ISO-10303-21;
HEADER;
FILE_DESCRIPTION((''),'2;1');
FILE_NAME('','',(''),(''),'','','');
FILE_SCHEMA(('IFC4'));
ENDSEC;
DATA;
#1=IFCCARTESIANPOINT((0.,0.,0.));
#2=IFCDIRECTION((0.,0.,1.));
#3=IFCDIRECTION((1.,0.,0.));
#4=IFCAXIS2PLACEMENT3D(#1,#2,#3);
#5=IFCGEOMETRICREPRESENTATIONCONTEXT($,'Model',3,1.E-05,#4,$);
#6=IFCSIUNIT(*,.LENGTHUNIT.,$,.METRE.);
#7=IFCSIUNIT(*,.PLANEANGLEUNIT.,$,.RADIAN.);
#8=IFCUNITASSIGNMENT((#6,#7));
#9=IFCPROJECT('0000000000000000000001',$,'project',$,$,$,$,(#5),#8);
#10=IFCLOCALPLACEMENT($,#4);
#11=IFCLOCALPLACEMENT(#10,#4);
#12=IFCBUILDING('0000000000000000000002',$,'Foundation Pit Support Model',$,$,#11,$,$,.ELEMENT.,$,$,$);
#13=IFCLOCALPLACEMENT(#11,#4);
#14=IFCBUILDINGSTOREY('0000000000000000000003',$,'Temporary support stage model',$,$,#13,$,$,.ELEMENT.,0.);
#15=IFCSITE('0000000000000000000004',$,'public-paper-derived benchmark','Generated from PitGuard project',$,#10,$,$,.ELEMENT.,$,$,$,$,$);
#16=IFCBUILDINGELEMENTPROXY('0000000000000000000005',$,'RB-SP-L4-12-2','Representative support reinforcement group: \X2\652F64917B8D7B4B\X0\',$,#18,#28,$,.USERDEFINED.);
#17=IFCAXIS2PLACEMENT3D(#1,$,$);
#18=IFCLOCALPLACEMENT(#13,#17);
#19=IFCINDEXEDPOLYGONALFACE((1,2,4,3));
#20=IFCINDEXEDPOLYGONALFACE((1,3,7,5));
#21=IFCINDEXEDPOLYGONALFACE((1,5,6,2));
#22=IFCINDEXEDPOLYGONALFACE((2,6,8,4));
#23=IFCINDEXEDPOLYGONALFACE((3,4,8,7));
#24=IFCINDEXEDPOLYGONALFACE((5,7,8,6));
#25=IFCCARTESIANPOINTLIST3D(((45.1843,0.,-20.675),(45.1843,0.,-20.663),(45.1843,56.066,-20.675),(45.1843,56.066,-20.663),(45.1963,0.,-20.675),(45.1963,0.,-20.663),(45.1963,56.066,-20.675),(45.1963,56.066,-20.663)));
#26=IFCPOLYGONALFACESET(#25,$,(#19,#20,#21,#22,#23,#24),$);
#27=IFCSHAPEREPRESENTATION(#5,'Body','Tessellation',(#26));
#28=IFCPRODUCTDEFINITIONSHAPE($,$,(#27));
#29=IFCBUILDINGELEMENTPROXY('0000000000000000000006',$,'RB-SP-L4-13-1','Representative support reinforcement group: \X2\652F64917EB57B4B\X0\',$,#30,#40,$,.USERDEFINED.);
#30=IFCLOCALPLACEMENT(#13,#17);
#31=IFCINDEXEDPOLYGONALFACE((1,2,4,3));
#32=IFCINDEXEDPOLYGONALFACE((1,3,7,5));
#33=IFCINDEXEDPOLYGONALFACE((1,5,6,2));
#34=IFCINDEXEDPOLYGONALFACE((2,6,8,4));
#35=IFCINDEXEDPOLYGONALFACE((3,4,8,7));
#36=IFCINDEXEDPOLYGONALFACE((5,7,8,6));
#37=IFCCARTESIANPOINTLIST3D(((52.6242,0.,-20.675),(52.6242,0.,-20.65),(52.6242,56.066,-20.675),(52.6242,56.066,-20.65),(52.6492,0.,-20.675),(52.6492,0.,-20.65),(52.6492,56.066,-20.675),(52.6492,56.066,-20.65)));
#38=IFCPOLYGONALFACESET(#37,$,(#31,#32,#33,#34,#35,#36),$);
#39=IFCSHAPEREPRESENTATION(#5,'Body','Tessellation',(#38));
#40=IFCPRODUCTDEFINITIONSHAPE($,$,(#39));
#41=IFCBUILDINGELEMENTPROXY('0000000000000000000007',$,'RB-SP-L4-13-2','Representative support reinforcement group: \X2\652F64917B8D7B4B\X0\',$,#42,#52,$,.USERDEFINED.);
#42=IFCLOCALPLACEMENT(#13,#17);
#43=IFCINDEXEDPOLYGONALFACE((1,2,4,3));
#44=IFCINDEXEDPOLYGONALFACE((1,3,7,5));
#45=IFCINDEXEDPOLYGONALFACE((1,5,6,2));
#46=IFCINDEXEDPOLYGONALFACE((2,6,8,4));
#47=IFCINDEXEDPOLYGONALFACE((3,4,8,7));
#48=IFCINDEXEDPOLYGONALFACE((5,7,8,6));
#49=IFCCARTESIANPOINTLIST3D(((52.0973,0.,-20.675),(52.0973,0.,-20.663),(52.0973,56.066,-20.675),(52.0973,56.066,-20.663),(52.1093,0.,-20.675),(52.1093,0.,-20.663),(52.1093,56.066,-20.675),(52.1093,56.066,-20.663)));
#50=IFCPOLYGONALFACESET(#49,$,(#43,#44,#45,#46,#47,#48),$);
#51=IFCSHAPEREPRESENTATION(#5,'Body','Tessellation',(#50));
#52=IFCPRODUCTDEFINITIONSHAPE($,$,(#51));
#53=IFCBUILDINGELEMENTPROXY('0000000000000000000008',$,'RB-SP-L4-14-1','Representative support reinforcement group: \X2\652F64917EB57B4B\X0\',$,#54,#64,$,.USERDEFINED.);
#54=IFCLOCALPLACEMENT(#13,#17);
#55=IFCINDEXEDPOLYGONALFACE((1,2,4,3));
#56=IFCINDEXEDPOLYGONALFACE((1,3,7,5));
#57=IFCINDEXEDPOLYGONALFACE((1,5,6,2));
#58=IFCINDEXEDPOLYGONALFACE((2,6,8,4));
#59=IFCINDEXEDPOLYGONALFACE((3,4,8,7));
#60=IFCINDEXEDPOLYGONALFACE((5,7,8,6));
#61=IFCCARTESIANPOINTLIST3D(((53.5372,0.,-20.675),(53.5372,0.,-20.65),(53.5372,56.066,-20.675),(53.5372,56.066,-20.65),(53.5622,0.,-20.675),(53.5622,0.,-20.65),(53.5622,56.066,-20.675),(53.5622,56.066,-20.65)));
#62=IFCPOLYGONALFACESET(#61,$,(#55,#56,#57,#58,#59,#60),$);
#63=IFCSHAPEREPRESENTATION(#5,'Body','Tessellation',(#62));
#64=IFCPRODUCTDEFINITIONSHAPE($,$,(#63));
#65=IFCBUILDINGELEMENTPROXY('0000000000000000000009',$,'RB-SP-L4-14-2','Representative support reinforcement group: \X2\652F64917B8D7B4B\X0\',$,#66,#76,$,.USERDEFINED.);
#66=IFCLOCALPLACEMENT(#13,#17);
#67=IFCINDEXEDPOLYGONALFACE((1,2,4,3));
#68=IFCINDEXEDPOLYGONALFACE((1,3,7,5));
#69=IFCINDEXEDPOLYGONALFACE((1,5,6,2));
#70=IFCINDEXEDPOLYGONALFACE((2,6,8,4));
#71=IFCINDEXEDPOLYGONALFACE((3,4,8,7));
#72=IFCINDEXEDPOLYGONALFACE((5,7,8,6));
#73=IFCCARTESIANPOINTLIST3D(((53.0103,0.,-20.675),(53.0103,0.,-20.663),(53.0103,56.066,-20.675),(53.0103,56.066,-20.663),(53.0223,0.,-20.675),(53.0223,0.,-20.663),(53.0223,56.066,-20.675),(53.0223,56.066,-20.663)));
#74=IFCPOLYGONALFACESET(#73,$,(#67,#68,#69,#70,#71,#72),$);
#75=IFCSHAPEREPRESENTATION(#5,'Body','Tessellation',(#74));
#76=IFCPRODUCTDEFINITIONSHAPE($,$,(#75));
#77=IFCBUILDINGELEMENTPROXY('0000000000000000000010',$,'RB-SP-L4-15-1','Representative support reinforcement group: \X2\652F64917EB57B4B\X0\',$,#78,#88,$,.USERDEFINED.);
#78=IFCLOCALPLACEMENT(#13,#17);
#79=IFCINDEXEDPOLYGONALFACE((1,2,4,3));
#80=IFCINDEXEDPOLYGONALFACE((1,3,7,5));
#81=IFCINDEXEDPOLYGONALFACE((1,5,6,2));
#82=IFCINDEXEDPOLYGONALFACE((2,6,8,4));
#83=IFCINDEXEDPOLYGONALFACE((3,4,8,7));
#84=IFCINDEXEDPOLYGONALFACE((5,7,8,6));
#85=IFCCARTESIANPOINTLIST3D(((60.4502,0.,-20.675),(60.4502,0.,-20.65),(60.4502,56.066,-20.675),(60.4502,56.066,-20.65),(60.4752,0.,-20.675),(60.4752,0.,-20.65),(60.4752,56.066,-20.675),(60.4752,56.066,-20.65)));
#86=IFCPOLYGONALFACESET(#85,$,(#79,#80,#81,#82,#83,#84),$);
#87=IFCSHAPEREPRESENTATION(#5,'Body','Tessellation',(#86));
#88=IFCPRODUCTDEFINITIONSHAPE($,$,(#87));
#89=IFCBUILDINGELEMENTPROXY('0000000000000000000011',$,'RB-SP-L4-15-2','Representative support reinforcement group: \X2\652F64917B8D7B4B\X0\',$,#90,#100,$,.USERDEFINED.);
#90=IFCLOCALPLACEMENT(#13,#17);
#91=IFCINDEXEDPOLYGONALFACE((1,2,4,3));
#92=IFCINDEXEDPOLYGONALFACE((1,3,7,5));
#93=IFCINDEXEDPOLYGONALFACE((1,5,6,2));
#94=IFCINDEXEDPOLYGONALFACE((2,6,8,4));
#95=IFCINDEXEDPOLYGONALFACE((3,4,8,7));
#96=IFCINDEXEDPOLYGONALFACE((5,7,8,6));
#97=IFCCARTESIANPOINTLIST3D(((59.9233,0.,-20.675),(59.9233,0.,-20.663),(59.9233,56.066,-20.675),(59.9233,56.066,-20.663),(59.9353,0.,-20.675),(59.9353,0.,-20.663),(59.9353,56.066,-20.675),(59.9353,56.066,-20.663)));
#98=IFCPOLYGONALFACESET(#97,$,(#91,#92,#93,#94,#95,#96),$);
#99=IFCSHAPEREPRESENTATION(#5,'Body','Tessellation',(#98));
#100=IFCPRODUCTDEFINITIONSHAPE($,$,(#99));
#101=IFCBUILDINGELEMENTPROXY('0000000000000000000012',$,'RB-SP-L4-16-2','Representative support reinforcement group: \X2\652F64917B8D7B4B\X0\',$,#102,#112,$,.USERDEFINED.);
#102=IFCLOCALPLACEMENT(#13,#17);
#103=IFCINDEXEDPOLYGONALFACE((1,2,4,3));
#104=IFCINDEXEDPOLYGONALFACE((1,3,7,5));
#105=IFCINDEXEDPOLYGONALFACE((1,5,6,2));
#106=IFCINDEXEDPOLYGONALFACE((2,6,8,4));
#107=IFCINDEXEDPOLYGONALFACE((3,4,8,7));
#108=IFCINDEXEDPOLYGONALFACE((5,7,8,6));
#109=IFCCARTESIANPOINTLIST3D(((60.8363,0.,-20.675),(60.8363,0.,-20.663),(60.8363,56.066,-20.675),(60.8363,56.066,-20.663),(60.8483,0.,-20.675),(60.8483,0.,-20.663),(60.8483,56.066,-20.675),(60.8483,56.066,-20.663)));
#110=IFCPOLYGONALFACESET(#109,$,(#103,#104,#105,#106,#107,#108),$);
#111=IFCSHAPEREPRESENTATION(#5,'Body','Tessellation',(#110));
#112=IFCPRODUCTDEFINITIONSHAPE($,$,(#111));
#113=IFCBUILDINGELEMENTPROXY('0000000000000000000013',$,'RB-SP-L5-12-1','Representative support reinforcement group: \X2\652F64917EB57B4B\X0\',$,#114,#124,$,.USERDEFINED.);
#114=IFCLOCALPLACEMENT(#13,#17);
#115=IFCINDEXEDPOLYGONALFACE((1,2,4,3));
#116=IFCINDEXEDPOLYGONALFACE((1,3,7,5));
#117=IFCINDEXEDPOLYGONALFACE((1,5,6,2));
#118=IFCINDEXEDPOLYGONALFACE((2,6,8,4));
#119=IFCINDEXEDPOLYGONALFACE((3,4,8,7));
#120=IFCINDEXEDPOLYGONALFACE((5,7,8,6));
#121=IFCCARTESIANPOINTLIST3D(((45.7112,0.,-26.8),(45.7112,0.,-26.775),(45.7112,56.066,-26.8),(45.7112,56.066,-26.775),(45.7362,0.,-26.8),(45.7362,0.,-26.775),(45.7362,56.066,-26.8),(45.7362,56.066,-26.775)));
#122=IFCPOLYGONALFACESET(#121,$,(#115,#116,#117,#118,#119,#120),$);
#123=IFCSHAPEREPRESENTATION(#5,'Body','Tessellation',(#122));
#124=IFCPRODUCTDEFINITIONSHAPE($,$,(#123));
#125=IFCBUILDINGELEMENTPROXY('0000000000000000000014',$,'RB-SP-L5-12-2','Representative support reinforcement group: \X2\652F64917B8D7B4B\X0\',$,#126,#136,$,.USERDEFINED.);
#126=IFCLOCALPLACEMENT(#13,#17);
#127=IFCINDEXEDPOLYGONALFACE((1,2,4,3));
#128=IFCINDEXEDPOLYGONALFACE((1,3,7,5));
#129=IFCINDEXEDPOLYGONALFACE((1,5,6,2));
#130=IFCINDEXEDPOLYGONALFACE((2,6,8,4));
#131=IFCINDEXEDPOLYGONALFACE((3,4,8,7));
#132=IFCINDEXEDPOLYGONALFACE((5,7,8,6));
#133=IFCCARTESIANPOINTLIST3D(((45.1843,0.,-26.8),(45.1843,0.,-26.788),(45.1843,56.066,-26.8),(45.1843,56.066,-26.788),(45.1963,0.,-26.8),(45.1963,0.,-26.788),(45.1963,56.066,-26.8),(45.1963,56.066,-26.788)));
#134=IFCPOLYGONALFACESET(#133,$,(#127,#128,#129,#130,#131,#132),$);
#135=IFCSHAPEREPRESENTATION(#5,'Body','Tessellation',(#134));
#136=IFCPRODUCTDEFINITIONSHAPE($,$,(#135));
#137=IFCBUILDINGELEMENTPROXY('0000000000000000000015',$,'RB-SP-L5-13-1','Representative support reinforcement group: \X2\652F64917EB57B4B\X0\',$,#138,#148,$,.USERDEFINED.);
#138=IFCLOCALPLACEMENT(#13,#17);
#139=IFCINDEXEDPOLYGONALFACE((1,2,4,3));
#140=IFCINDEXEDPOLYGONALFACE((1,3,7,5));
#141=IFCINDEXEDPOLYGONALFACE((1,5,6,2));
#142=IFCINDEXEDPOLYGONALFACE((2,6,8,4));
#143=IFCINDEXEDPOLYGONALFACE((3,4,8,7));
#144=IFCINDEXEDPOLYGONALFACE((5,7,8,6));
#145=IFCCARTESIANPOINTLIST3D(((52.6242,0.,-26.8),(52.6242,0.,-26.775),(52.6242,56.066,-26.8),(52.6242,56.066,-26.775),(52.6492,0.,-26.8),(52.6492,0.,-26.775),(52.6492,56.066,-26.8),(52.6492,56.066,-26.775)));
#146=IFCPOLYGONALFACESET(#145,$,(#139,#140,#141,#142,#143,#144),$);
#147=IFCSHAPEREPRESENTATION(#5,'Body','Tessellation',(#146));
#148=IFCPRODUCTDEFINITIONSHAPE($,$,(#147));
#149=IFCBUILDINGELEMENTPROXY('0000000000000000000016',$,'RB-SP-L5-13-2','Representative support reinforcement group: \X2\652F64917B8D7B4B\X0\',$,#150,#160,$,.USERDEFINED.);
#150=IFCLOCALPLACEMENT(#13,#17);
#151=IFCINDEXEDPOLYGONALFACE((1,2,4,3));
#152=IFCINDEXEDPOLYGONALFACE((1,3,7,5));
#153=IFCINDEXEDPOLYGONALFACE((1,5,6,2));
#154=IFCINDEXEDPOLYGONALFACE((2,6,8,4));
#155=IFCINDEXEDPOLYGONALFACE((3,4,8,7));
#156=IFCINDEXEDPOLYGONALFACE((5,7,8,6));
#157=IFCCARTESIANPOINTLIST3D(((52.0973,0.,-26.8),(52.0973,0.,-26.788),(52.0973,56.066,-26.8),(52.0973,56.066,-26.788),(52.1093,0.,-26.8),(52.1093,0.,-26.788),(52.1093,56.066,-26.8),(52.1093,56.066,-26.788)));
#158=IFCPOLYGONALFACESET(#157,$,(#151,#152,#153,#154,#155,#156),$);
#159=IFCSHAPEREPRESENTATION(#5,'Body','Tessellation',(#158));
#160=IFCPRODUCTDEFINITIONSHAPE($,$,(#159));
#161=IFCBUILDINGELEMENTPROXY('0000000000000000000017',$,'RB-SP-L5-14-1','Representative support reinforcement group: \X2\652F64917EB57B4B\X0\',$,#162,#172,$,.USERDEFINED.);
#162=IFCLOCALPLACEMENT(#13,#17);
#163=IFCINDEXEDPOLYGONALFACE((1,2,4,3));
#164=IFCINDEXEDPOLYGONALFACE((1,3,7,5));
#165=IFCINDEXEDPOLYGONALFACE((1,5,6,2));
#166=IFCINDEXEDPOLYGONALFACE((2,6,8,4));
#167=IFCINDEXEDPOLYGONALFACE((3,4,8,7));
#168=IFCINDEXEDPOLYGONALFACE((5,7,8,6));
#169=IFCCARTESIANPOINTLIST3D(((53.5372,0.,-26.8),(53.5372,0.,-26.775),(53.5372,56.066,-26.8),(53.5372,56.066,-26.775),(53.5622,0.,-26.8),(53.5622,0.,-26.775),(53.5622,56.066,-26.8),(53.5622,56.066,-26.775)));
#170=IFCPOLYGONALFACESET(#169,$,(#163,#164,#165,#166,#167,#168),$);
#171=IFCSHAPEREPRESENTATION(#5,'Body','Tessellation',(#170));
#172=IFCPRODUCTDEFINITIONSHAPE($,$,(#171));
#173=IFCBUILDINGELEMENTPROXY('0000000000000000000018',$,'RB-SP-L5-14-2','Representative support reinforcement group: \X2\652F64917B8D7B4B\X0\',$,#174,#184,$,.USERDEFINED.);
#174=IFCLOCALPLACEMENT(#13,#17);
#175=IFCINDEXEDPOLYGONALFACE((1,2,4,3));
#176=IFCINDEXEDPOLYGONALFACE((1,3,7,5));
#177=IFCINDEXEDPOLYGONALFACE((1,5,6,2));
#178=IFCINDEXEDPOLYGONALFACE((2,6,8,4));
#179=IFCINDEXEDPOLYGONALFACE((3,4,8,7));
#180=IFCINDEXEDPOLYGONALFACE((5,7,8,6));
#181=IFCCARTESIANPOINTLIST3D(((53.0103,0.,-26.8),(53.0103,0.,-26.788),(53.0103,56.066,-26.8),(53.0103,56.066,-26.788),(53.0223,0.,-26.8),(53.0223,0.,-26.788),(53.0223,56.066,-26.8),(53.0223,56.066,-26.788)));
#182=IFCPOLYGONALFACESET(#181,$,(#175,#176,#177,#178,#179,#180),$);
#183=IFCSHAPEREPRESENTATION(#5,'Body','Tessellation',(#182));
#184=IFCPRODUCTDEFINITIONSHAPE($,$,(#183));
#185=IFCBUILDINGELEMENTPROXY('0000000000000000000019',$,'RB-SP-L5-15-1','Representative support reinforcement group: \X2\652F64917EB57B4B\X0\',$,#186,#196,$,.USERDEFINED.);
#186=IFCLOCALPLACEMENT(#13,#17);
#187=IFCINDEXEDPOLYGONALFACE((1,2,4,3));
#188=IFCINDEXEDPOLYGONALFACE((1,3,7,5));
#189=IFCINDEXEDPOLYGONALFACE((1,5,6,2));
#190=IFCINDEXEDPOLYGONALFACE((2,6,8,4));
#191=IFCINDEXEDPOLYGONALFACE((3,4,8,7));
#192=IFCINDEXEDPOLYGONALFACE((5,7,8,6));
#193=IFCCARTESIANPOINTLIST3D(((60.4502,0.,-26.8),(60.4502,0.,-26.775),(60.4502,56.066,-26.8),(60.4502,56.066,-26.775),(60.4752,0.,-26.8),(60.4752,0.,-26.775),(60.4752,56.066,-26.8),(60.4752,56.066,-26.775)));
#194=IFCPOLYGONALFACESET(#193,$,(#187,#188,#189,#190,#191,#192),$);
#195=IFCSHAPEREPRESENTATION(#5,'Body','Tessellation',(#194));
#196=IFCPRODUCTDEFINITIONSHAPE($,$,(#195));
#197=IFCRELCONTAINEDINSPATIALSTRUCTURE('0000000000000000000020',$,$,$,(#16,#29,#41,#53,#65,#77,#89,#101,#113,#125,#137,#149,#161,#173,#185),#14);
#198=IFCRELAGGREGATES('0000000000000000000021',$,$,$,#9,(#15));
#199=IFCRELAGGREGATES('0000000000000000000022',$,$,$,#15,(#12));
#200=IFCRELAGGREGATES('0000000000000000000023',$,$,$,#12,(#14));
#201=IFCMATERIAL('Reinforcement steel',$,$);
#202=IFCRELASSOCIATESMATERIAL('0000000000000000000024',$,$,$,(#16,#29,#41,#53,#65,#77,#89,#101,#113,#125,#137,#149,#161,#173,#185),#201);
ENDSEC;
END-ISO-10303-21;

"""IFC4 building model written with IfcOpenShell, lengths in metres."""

from ifc_helpers import new_model, si_unit, frame, origin_with_axes, origin_2d, place, context, project, spatial, rectangle, extrude, material, element, save


model = new_model("IFC4")

# Units and contexts
model_context = context("Model", 3, precision=1e-05, world=origin_with_axes())
ifc_project = project(units=[si_unit("LENGTHUNIT", "METRE"), si_unit("PLANEANGLEUNIT", "RADIAN")], contexts=[model_context])

# Site, building, storey
site_placement = place(None, origin_with_axes())
site = spatial("IfcSite", under=ifc_project, at=site_placement, Name="public-paper-derived benchmark", Description="Generated from PitGuard project", CompositionType="ELEMENT")
building_placement = place(site_placement, origin_with_axes())
building = spatial("IfcBuilding", under=site, at=building_placement, Name="Foundation Pit Support Model", CompositionType="ELEMENT")
storey_placement = place(building_placement, origin_with_axes())
storey = spatial("IfcBuildingStorey", under=building, at=storey_placement, Name="Temporary support stage model", CompositionType="ELEMENT", Elevation=0.0)

# Building element proxies
ifc_material_1 = material(Name="Reinforcement steel")
proxy_1_placement = place(storey_placement, frame((45.1903, 28.033, -20.675), z_axis=(0.0, 0.0, 1.0), x_axis=(0.0, 1.0, 0.0)))
element("IfcBuildingElementProxy", 1, at=proxy_1_placement, inside=storey, material=ifc_material_1, Name="RB-SP-L4-12-2", Description="Representative support reinforcement group: 支撑箍筋", PredefinedType="USERDEFINED", context=model_context, shape_type="SweptSolid", body=[
    extrude(rectangle(XDim=56.066, YDim=0.012, at=origin_2d()), origin_with_axes(), (0.0, 0.0, 1.0), 0.012),
])
proxy_2_placement = place(storey_placement, frame((52.6367, 28.033, -20.675), z_axis=(0.0, 0.0, 1.0), x_axis=(0.0, 1.0, 0.0)))
element("IfcBuildingElementProxy", 2, at=proxy_2_placement, inside=storey, material=ifc_material_1, Name="RB-SP-L4-13-1", Description="Representative support reinforcement group: 支撑纵筋", PredefinedType="USERDEFINED", context=model_context, shape_type="SweptSolid", body=[
    extrude(rectangle(XDim=56.066, YDim=0.025, at=origin_2d()), origin_with_axes(), (0.0, 0.0, 1.0), 0.025),
])
proxy_3_placement = place(storey_placement, frame((52.1033, 28.033, -20.675), z_axis=(0.0, 0.0, 1.0), x_axis=(0.0, 1.0, 0.0)))
element("IfcBuildingElementProxy", 3, at=proxy_3_placement, inside=storey, material=ifc_material_1, Name="RB-SP-L4-13-2", Description="Representative support reinforcement group: 支撑箍筋", PredefinedType="USERDEFINED", context=model_context, shape_type="SweptSolid", body=[
    extrude(rectangle(XDim=56.066, YDim=0.012, at=origin_2d()), origin_with_axes(), (0.0, 0.0, 1.0), 0.012),
])
proxy_4_placement = place(storey_placement, frame((53.5497, 28.033, -20.675), z_axis=(0.0, 0.0, 1.0), x_axis=(0.0, 1.0, 0.0)))
element("IfcBuildingElementProxy", 4, at=proxy_4_placement, inside=storey, material=ifc_material_1, Name="RB-SP-L4-14-1", Description="Representative support reinforcement group: 支撑纵筋", PredefinedType="USERDEFINED", context=model_context, shape_type="SweptSolid", body=[
    extrude(rectangle(XDim=56.066, YDim=0.025, at=origin_2d()), origin_with_axes(), (0.0, 0.0, 1.0), 0.025),
])
proxy_5_placement = place(storey_placement, frame((53.0163, 28.033, -20.675), z_axis=(0.0, 0.0, 1.0), x_axis=(0.0, 1.0, 0.0)))
element("IfcBuildingElementProxy", 5, at=proxy_5_placement, inside=storey, material=ifc_material_1, Name="RB-SP-L4-14-2", Description="Representative support reinforcement group: 支撑箍筋", PredefinedType="USERDEFINED", context=model_context, shape_type="SweptSolid", body=[
    extrude(rectangle(XDim=56.066, YDim=0.012, at=origin_2d()), origin_with_axes(), (0.0, 0.0, 1.0), 0.012),
])
proxy_6_placement = place(storey_placement, frame((60.4627, 28.033, -20.675), z_axis=(0.0, 0.0, 1.0), x_axis=(0.0, 1.0, 0.0)))
element("IfcBuildingElementProxy", 6, at=proxy_6_placement, inside=storey, material=ifc_material_1, Name="RB-SP-L4-15-1", Description="Representative support reinforcement group: 支撑纵筋", PredefinedType="USERDEFINED", context=model_context, shape_type="SweptSolid", body=[
    extrude(rectangle(XDim=56.066, YDim=0.025, at=origin_2d()), origin_with_axes(), (0.0, 0.0, 1.0), 0.025),
])
for number, where, z_axis, x_axis, name in (
    (7, (59.9293, 28.033, -20.675), (0.0, 0.0, 1.0), (0.0, 1.0, 0.0), "RB-SP-L4-15-2"),
    (8, (60.8423, 28.033, -20.675), (0.0, 0.0, 1.0), (0.0, 1.0, 0.0), "RB-SP-L4-16-2"),
):
    element("IfcBuildingElementProxy", number, at=place(storey_placement, frame(where, z_axis=z_axis, x_axis=x_axis)), inside=storey, material=ifc_material_1, Name=name, Description="Representative support reinforcement group: 支撑箍筋", PredefinedType="USERDEFINED", context=model_context, shape_type="SweptSolid", body=[
        extrude(rectangle(XDim=56.066, YDim=0.012, at=origin_2d()), origin_with_axes(), (0.0, 0.0, 1.0), 0.012),
    ])
proxy_7_placement = place(storey_placement, frame((45.7237, 28.033, -26.8), z_axis=(0.0, 0.0, 1.0), x_axis=(0.0, 1.0, 0.0)))
element("IfcBuildingElementProxy", 9, at=proxy_7_placement, inside=storey, material=ifc_material_1, Name="RB-SP-L5-12-1", Description="Representative support reinforcement group: 支撑纵筋", PredefinedType="USERDEFINED", context=model_context, shape_type="SweptSolid", body=[
    extrude(rectangle(XDim=56.066, YDim=0.025, at=origin_2d()), origin_with_axes(), (0.0, 0.0, 1.0), 0.025),
])
proxy_8_placement = place(storey_placement, frame((45.1903, 28.033, -26.8), z_axis=(0.0, 0.0, 1.0), x_axis=(0.0, 1.0, 0.0)))
element("IfcBuildingElementProxy", 10, at=proxy_8_placement, inside=storey, material=ifc_material_1, Name="RB-SP-L5-12-2", Description="Representative support reinforcement group: 支撑箍筋", PredefinedType="USERDEFINED", context=model_context, shape_type="SweptSolid", body=[
    extrude(rectangle(XDim=56.066, YDim=0.012, at=origin_2d()), origin_with_axes(), (0.0, 0.0, 1.0), 0.012),
])
proxy_9_placement = place(storey_placement, frame((52.6367, 28.033, -26.8), z_axis=(0.0, 0.0, 1.0), x_axis=(0.0, 1.0, 0.0)))
element("IfcBuildingElementProxy", 11, at=proxy_9_placement, inside=storey, material=ifc_material_1, Name="RB-SP-L5-13-1", Description="Representative support reinforcement group: 支撑纵筋", PredefinedType="USERDEFINED", context=model_context, shape_type="SweptSolid", body=[
    extrude(rectangle(XDim=56.066, YDim=0.025, at=origin_2d()), origin_with_axes(), (0.0, 0.0, 1.0), 0.025),
])
proxy_10_placement = place(storey_placement, frame((52.1033, 28.033, -26.8), z_axis=(0.0, 0.0, 1.0), x_axis=(0.0, 1.0, 0.0)))
element("IfcBuildingElementProxy", 12, at=proxy_10_placement, inside=storey, material=ifc_material_1, Name="RB-SP-L5-13-2", Description="Representative support reinforcement group: 支撑箍筋", PredefinedType="USERDEFINED", context=model_context, shape_type="SweptSolid", body=[
    extrude(rectangle(XDim=56.066, YDim=0.012, at=origin_2d()), origin_with_axes(), (0.0, 0.0, 1.0), 0.012),
])
proxy_11_placement = place(storey_placement, frame((53.5497, 28.033, -26.8), z_axis=(0.0, 0.0, 1.0), x_axis=(0.0, 1.0, 0.0)))
element("IfcBuildingElementProxy", 13, at=proxy_11_placement, inside=storey, material=ifc_material_1, Name="RB-SP-L5-14-1", Description="Representative support reinforcement group: 支撑纵筋", PredefinedType="USERDEFINED", context=model_context, shape_type="SweptSolid", body=[
    extrude(rectangle(XDim=56.066, YDim=0.025, at=origin_2d()), origin_with_axes(), (0.0, 0.0, 1.0), 0.025),
])
proxy_12_placement = place(storey_placement, frame((53.0163, 28.033, -26.8), z_axis=(0.0, 0.0, 1.0), x_axis=(0.0, 1.0, 0.0)))
element("IfcBuildingElementProxy", 14, at=proxy_12_placement, inside=storey, material=ifc_material_1, Name="RB-SP-L5-14-2", Description="Representative support reinforcement group: 支撑箍筋", PredefinedType="USERDEFINED", context=model_context, shape_type="SweptSolid", body=[
    extrude(rectangle(XDim=56.066, YDim=0.012, at=origin_2d()), origin_with_axes(), (0.0, 0.0, 1.0), 0.012),
])
proxy_13_placement = place(storey_placement, frame((60.4627, 28.033, -26.8), z_axis=(0.0, 0.0, 1.0), x_axis=(0.0, 1.0, 0.0)))
element("IfcBuildingElementProxy", 15, at=proxy_13_placement, inside=storey, material=ifc_material_1, Name="RB-SP-L5-15-1", Description="Representative support reinforcement group: 支撑纵筋", PredefinedType="USERDEFINED", context=model_context, shape_type="SweptSolid", body=[
    extrude(rectangle(XDim=56.066, YDim=0.025, at=origin_2d()), origin_with_axes(), (0.0, 0.0, 1.0), 0.025),
])

save(model, "model.ifc")
